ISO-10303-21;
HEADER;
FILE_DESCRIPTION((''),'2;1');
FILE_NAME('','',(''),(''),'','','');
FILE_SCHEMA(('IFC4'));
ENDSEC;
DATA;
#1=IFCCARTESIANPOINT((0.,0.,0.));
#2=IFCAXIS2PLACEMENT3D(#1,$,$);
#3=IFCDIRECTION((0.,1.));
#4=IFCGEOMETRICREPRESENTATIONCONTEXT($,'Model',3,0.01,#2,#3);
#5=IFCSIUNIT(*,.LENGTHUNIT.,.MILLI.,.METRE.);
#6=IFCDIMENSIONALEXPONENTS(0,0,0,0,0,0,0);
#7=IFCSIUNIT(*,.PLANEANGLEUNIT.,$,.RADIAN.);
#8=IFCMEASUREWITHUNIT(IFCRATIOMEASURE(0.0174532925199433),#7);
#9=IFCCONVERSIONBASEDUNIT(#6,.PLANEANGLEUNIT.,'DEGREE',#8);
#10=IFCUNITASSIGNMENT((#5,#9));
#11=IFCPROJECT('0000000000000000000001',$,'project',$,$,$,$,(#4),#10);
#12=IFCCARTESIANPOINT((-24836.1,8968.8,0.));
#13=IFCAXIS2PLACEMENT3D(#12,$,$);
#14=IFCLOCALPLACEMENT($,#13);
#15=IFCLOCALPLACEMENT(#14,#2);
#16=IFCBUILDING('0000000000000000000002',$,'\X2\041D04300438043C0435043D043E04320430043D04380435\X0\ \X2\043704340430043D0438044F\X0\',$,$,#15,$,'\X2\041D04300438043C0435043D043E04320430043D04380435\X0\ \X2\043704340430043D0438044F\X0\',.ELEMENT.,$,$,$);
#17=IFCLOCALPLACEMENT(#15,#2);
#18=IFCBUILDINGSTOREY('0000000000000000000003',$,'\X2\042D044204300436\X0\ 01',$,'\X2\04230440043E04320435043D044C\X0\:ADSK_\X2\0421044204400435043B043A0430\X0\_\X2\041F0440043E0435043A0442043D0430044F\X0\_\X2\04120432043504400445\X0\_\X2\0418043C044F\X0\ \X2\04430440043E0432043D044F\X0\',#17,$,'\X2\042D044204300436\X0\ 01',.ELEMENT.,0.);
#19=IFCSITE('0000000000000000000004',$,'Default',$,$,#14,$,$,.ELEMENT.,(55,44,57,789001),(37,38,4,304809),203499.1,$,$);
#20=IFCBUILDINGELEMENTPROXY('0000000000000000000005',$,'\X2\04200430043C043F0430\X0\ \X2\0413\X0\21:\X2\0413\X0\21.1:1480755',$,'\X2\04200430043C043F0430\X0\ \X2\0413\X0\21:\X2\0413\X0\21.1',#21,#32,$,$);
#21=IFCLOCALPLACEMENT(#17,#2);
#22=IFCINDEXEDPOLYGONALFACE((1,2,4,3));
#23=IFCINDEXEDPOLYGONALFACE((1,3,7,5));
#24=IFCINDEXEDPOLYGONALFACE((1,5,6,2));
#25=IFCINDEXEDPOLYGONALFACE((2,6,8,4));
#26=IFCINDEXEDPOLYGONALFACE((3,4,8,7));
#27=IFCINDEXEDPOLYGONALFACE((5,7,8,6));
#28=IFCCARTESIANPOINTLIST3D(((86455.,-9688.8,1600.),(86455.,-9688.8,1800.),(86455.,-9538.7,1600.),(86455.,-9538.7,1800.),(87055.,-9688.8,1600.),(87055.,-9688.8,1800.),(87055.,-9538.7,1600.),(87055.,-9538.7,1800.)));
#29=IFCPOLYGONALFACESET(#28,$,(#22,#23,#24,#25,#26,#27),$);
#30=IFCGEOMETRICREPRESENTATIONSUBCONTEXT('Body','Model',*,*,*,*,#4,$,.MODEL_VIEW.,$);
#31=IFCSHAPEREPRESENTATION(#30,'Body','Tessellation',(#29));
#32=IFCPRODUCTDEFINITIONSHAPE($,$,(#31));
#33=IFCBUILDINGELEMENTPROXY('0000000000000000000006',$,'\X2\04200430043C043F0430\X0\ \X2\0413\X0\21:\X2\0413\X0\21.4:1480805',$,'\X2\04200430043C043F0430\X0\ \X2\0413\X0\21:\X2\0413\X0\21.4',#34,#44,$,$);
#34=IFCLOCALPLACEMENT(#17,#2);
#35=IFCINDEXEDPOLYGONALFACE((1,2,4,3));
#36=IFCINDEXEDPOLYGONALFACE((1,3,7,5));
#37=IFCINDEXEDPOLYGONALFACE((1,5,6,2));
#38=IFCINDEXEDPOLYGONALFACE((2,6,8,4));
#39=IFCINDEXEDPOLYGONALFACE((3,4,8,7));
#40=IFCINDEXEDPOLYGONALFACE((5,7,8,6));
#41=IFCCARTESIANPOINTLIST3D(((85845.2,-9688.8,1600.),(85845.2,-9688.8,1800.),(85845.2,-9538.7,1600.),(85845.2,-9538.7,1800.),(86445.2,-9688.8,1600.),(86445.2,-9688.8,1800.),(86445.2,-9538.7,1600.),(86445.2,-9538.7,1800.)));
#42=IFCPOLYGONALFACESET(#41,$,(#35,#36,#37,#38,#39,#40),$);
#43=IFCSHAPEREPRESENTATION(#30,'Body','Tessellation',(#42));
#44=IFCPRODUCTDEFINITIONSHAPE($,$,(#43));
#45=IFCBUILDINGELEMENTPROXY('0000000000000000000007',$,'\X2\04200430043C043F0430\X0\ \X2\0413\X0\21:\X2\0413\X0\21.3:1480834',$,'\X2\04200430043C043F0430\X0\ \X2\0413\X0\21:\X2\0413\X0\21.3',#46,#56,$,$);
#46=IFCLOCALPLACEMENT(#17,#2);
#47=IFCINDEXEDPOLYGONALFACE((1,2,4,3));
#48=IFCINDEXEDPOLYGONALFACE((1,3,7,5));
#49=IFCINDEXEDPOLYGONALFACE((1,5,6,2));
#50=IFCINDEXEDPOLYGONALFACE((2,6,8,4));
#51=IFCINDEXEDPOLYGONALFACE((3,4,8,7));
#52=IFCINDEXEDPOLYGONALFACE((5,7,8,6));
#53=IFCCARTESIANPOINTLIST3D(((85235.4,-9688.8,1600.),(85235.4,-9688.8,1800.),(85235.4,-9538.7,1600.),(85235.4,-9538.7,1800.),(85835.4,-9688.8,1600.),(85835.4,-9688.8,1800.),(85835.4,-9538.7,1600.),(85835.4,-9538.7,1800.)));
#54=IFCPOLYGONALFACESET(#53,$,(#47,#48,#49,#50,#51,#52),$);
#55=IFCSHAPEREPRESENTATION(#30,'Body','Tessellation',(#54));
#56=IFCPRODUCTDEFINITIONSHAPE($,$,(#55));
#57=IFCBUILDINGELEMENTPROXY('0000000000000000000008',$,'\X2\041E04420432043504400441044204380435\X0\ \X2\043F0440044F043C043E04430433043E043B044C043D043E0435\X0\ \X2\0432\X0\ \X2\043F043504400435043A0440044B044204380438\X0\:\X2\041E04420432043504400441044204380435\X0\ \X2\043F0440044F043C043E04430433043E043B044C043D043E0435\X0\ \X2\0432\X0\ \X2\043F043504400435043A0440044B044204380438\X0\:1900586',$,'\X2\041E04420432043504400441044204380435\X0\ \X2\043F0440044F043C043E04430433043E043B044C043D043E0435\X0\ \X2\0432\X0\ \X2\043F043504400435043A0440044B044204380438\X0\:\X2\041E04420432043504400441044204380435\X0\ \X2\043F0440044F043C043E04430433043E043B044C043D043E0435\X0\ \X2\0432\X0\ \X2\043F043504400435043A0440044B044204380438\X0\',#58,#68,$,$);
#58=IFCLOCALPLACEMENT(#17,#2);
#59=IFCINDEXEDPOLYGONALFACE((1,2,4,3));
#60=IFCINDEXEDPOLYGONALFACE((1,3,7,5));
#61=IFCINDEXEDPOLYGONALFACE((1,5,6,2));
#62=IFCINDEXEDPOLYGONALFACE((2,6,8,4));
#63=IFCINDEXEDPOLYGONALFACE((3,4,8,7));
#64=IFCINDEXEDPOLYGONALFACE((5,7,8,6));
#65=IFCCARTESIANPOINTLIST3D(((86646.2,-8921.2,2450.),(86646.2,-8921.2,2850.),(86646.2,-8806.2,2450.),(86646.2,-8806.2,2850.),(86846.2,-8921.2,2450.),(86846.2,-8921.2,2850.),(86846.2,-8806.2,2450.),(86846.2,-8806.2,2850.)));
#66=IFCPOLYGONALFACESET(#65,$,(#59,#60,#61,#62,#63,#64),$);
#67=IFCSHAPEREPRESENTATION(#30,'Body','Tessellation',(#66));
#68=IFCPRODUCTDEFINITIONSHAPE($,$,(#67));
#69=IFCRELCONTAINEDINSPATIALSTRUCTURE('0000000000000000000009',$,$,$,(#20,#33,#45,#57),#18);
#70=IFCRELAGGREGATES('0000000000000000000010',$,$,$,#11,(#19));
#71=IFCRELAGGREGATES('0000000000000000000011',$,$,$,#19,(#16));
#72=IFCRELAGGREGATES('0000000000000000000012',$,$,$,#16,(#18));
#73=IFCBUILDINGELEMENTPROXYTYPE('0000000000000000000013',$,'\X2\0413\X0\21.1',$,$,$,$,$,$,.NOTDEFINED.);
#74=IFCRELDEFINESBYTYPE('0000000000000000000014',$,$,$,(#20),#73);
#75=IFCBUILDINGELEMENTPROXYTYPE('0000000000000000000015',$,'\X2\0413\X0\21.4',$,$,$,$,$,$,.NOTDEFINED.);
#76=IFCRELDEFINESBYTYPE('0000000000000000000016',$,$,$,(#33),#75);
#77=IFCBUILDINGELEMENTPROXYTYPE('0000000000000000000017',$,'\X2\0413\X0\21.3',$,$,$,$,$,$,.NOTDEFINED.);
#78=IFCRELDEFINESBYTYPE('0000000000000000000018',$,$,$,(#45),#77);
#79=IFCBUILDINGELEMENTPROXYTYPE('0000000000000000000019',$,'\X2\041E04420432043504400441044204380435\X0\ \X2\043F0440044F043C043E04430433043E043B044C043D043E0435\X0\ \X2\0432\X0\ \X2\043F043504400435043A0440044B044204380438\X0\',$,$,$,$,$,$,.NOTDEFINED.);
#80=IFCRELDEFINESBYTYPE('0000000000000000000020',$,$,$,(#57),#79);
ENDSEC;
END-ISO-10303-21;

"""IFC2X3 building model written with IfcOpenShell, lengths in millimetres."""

from ifc_helpers import new_model, entity, si_unit, converted_unit, direction, frame, origin, origin_2d_with_axis, place, context, subcontext, project, spatial, rectangle, extrude, type_object, element, save


model = new_model("IFC2X3")

# Units and contexts
model_context = context("Model", 3, precision=0.01, world=origin(), true_north=direction((0.0, 1.0)))
body_context = subcontext(model_context, "Body", "Model", "MODEL_VIEW")
ifc_project = project(units=[si_unit("LENGTHUNIT", "METRE", prefix="MILLI"), converted_unit("PLANEANGLEUNIT", "DEGREE", entity("IfcRatioMeasure", 0.0174532925199433), si_unit("PLANEANGLEUNIT", "RADIAN"), dimensions=[0, 0, 0, 0, 0, 0, 0])], contexts=[model_context])

# Site, building, storey
site_placement = place(None, frame((-24836.1, 8968.8, 0.0)))
site = spatial("IfcSite", under=ifc_project, at=site_placement, Name="Default", CompositionType="ELEMENT", RefLatitude=(55, 44, 57, 789001), RefLongitude=(37, 38, 4, 304809), RefElevation=203499.1)
building_placement = place(site_placement, origin())
building = spatial("IfcBuilding", under=site, at=building_placement, Name="Наименование здания", LongName="Наименование здания", CompositionType="ELEMENT")
storey_placement = place(building_placement, origin())
storey = spatial("IfcBuildingStorey", under=building, at=storey_placement, Name="Этаж 01", ObjectType="Уровень:ADSK_Стрелка_Проектная_Вверх_Имя уровня", LongName="Этаж 01", CompositionType="ELEMENT", Elevation=0.0)

# Building element proxies
building_element_proxy_type_1 = type_object("IfcBuildingElementProxyType", Name="Г21.1", PredefinedType="NOTDEFINED")
proxy_1_placement = place(storey_placement, frame((86455.0, -9688.8, 1600.0)))
element("IfcBuildingElementProxy", 1, at=proxy_1_placement, inside=storey, type_object=building_element_proxy_type_1, Name="Рампа Г21:Г21.1:1480755", ObjectType="Рампа Г21:Г21.1", context=body_context, shape_type="SweptSolid", body=[
    extrude(rectangle(XDim=150.0, YDim=600.0, at=origin_2d_with_axis()), frame((300.0, 75.0, 0.0), z_axis=(0.0, 0.0, 1.0), x_axis=(0.0, 1.0, 0.0)), (0.0, 0.0, 1.0), 200.0),
])
building_element_proxy_type_2 = type_object("IfcBuildingElementProxyType", Name="Г21.4", PredefinedType="NOTDEFINED")
proxy_2_placement = place(storey_placement, frame((85845.2, -9688.8, 1600.0)))
element("IfcBuildingElementProxy", 2, at=proxy_2_placement, inside=storey, type_object=building_element_proxy_type_2, Name="Рампа Г21:Г21.4:1480805", ObjectType="Рампа Г21:Г21.4", context=body_context, shape_type="SweptSolid", body=[
    extrude(rectangle(XDim=150.0, YDim=600.0, at=origin_2d_with_axis()), frame((300.0, 75.0, 0.0), z_axis=(0.0, 0.0, 1.0), x_axis=(0.0, 1.0, 0.0)), (0.0, 0.0, 1.0), 200.0),
])
building_element_proxy_type_3 = type_object("IfcBuildingElementProxyType", Name="Г21.3", PredefinedType="NOTDEFINED")
proxy_3_placement = place(storey_placement, frame((85235.4, -9688.8, 1600.0)))
element("IfcBuildingElementProxy", 3, at=proxy_3_placement, inside=storey, type_object=building_element_proxy_type_3, Name="Рампа Г21:Г21.3:1480834", ObjectType="Рампа Г21:Г21.3", context=body_context, shape_type="SweptSolid", body=[
    extrude(rectangle(XDim=150.0, YDim=600.0, at=origin_2d_with_axis()), frame((300.0, 75.0, 0.0), z_axis=(0.0, 0.0, 1.0), x_axis=(0.0, 1.0, 0.0)), (0.0, 0.0, 1.0), 200.0),
])
building_element_proxy_type_4 = type_object("IfcBuildingElementProxyType", Name="Отверстие прямоугольное в перекрытии", PredefinedType="NOTDEFINED")
proxy_4_placement = place(storey_placement, frame((86646.2, -8921.2, 2450.0)))
element("IfcBuildingElementProxy", 4, at=proxy_4_placement, inside=storey, type_object=building_element_proxy_type_4, Name="Отверстие прямоугольное в перекрытии:Отверстие прямоугольное в перекрытии:1900586", ObjectType="Отверстие прямоугольное в перекрытии:Отверстие прямоугольное в перекрытии", context=body_context, shape_type="SweptSolid", body=[
    extrude(rectangle(XDim=200.0, YDim=115.0, at=origin_2d_with_axis()), frame((100.0, 57.5, 0.0), z_axis=(0.0, 0.0, 1.0), x_axis=(-1.0, 0.0, 0.0)), (0.0, 0.0, 1.0), 400.0),
])

save(model, "model.ifc")
